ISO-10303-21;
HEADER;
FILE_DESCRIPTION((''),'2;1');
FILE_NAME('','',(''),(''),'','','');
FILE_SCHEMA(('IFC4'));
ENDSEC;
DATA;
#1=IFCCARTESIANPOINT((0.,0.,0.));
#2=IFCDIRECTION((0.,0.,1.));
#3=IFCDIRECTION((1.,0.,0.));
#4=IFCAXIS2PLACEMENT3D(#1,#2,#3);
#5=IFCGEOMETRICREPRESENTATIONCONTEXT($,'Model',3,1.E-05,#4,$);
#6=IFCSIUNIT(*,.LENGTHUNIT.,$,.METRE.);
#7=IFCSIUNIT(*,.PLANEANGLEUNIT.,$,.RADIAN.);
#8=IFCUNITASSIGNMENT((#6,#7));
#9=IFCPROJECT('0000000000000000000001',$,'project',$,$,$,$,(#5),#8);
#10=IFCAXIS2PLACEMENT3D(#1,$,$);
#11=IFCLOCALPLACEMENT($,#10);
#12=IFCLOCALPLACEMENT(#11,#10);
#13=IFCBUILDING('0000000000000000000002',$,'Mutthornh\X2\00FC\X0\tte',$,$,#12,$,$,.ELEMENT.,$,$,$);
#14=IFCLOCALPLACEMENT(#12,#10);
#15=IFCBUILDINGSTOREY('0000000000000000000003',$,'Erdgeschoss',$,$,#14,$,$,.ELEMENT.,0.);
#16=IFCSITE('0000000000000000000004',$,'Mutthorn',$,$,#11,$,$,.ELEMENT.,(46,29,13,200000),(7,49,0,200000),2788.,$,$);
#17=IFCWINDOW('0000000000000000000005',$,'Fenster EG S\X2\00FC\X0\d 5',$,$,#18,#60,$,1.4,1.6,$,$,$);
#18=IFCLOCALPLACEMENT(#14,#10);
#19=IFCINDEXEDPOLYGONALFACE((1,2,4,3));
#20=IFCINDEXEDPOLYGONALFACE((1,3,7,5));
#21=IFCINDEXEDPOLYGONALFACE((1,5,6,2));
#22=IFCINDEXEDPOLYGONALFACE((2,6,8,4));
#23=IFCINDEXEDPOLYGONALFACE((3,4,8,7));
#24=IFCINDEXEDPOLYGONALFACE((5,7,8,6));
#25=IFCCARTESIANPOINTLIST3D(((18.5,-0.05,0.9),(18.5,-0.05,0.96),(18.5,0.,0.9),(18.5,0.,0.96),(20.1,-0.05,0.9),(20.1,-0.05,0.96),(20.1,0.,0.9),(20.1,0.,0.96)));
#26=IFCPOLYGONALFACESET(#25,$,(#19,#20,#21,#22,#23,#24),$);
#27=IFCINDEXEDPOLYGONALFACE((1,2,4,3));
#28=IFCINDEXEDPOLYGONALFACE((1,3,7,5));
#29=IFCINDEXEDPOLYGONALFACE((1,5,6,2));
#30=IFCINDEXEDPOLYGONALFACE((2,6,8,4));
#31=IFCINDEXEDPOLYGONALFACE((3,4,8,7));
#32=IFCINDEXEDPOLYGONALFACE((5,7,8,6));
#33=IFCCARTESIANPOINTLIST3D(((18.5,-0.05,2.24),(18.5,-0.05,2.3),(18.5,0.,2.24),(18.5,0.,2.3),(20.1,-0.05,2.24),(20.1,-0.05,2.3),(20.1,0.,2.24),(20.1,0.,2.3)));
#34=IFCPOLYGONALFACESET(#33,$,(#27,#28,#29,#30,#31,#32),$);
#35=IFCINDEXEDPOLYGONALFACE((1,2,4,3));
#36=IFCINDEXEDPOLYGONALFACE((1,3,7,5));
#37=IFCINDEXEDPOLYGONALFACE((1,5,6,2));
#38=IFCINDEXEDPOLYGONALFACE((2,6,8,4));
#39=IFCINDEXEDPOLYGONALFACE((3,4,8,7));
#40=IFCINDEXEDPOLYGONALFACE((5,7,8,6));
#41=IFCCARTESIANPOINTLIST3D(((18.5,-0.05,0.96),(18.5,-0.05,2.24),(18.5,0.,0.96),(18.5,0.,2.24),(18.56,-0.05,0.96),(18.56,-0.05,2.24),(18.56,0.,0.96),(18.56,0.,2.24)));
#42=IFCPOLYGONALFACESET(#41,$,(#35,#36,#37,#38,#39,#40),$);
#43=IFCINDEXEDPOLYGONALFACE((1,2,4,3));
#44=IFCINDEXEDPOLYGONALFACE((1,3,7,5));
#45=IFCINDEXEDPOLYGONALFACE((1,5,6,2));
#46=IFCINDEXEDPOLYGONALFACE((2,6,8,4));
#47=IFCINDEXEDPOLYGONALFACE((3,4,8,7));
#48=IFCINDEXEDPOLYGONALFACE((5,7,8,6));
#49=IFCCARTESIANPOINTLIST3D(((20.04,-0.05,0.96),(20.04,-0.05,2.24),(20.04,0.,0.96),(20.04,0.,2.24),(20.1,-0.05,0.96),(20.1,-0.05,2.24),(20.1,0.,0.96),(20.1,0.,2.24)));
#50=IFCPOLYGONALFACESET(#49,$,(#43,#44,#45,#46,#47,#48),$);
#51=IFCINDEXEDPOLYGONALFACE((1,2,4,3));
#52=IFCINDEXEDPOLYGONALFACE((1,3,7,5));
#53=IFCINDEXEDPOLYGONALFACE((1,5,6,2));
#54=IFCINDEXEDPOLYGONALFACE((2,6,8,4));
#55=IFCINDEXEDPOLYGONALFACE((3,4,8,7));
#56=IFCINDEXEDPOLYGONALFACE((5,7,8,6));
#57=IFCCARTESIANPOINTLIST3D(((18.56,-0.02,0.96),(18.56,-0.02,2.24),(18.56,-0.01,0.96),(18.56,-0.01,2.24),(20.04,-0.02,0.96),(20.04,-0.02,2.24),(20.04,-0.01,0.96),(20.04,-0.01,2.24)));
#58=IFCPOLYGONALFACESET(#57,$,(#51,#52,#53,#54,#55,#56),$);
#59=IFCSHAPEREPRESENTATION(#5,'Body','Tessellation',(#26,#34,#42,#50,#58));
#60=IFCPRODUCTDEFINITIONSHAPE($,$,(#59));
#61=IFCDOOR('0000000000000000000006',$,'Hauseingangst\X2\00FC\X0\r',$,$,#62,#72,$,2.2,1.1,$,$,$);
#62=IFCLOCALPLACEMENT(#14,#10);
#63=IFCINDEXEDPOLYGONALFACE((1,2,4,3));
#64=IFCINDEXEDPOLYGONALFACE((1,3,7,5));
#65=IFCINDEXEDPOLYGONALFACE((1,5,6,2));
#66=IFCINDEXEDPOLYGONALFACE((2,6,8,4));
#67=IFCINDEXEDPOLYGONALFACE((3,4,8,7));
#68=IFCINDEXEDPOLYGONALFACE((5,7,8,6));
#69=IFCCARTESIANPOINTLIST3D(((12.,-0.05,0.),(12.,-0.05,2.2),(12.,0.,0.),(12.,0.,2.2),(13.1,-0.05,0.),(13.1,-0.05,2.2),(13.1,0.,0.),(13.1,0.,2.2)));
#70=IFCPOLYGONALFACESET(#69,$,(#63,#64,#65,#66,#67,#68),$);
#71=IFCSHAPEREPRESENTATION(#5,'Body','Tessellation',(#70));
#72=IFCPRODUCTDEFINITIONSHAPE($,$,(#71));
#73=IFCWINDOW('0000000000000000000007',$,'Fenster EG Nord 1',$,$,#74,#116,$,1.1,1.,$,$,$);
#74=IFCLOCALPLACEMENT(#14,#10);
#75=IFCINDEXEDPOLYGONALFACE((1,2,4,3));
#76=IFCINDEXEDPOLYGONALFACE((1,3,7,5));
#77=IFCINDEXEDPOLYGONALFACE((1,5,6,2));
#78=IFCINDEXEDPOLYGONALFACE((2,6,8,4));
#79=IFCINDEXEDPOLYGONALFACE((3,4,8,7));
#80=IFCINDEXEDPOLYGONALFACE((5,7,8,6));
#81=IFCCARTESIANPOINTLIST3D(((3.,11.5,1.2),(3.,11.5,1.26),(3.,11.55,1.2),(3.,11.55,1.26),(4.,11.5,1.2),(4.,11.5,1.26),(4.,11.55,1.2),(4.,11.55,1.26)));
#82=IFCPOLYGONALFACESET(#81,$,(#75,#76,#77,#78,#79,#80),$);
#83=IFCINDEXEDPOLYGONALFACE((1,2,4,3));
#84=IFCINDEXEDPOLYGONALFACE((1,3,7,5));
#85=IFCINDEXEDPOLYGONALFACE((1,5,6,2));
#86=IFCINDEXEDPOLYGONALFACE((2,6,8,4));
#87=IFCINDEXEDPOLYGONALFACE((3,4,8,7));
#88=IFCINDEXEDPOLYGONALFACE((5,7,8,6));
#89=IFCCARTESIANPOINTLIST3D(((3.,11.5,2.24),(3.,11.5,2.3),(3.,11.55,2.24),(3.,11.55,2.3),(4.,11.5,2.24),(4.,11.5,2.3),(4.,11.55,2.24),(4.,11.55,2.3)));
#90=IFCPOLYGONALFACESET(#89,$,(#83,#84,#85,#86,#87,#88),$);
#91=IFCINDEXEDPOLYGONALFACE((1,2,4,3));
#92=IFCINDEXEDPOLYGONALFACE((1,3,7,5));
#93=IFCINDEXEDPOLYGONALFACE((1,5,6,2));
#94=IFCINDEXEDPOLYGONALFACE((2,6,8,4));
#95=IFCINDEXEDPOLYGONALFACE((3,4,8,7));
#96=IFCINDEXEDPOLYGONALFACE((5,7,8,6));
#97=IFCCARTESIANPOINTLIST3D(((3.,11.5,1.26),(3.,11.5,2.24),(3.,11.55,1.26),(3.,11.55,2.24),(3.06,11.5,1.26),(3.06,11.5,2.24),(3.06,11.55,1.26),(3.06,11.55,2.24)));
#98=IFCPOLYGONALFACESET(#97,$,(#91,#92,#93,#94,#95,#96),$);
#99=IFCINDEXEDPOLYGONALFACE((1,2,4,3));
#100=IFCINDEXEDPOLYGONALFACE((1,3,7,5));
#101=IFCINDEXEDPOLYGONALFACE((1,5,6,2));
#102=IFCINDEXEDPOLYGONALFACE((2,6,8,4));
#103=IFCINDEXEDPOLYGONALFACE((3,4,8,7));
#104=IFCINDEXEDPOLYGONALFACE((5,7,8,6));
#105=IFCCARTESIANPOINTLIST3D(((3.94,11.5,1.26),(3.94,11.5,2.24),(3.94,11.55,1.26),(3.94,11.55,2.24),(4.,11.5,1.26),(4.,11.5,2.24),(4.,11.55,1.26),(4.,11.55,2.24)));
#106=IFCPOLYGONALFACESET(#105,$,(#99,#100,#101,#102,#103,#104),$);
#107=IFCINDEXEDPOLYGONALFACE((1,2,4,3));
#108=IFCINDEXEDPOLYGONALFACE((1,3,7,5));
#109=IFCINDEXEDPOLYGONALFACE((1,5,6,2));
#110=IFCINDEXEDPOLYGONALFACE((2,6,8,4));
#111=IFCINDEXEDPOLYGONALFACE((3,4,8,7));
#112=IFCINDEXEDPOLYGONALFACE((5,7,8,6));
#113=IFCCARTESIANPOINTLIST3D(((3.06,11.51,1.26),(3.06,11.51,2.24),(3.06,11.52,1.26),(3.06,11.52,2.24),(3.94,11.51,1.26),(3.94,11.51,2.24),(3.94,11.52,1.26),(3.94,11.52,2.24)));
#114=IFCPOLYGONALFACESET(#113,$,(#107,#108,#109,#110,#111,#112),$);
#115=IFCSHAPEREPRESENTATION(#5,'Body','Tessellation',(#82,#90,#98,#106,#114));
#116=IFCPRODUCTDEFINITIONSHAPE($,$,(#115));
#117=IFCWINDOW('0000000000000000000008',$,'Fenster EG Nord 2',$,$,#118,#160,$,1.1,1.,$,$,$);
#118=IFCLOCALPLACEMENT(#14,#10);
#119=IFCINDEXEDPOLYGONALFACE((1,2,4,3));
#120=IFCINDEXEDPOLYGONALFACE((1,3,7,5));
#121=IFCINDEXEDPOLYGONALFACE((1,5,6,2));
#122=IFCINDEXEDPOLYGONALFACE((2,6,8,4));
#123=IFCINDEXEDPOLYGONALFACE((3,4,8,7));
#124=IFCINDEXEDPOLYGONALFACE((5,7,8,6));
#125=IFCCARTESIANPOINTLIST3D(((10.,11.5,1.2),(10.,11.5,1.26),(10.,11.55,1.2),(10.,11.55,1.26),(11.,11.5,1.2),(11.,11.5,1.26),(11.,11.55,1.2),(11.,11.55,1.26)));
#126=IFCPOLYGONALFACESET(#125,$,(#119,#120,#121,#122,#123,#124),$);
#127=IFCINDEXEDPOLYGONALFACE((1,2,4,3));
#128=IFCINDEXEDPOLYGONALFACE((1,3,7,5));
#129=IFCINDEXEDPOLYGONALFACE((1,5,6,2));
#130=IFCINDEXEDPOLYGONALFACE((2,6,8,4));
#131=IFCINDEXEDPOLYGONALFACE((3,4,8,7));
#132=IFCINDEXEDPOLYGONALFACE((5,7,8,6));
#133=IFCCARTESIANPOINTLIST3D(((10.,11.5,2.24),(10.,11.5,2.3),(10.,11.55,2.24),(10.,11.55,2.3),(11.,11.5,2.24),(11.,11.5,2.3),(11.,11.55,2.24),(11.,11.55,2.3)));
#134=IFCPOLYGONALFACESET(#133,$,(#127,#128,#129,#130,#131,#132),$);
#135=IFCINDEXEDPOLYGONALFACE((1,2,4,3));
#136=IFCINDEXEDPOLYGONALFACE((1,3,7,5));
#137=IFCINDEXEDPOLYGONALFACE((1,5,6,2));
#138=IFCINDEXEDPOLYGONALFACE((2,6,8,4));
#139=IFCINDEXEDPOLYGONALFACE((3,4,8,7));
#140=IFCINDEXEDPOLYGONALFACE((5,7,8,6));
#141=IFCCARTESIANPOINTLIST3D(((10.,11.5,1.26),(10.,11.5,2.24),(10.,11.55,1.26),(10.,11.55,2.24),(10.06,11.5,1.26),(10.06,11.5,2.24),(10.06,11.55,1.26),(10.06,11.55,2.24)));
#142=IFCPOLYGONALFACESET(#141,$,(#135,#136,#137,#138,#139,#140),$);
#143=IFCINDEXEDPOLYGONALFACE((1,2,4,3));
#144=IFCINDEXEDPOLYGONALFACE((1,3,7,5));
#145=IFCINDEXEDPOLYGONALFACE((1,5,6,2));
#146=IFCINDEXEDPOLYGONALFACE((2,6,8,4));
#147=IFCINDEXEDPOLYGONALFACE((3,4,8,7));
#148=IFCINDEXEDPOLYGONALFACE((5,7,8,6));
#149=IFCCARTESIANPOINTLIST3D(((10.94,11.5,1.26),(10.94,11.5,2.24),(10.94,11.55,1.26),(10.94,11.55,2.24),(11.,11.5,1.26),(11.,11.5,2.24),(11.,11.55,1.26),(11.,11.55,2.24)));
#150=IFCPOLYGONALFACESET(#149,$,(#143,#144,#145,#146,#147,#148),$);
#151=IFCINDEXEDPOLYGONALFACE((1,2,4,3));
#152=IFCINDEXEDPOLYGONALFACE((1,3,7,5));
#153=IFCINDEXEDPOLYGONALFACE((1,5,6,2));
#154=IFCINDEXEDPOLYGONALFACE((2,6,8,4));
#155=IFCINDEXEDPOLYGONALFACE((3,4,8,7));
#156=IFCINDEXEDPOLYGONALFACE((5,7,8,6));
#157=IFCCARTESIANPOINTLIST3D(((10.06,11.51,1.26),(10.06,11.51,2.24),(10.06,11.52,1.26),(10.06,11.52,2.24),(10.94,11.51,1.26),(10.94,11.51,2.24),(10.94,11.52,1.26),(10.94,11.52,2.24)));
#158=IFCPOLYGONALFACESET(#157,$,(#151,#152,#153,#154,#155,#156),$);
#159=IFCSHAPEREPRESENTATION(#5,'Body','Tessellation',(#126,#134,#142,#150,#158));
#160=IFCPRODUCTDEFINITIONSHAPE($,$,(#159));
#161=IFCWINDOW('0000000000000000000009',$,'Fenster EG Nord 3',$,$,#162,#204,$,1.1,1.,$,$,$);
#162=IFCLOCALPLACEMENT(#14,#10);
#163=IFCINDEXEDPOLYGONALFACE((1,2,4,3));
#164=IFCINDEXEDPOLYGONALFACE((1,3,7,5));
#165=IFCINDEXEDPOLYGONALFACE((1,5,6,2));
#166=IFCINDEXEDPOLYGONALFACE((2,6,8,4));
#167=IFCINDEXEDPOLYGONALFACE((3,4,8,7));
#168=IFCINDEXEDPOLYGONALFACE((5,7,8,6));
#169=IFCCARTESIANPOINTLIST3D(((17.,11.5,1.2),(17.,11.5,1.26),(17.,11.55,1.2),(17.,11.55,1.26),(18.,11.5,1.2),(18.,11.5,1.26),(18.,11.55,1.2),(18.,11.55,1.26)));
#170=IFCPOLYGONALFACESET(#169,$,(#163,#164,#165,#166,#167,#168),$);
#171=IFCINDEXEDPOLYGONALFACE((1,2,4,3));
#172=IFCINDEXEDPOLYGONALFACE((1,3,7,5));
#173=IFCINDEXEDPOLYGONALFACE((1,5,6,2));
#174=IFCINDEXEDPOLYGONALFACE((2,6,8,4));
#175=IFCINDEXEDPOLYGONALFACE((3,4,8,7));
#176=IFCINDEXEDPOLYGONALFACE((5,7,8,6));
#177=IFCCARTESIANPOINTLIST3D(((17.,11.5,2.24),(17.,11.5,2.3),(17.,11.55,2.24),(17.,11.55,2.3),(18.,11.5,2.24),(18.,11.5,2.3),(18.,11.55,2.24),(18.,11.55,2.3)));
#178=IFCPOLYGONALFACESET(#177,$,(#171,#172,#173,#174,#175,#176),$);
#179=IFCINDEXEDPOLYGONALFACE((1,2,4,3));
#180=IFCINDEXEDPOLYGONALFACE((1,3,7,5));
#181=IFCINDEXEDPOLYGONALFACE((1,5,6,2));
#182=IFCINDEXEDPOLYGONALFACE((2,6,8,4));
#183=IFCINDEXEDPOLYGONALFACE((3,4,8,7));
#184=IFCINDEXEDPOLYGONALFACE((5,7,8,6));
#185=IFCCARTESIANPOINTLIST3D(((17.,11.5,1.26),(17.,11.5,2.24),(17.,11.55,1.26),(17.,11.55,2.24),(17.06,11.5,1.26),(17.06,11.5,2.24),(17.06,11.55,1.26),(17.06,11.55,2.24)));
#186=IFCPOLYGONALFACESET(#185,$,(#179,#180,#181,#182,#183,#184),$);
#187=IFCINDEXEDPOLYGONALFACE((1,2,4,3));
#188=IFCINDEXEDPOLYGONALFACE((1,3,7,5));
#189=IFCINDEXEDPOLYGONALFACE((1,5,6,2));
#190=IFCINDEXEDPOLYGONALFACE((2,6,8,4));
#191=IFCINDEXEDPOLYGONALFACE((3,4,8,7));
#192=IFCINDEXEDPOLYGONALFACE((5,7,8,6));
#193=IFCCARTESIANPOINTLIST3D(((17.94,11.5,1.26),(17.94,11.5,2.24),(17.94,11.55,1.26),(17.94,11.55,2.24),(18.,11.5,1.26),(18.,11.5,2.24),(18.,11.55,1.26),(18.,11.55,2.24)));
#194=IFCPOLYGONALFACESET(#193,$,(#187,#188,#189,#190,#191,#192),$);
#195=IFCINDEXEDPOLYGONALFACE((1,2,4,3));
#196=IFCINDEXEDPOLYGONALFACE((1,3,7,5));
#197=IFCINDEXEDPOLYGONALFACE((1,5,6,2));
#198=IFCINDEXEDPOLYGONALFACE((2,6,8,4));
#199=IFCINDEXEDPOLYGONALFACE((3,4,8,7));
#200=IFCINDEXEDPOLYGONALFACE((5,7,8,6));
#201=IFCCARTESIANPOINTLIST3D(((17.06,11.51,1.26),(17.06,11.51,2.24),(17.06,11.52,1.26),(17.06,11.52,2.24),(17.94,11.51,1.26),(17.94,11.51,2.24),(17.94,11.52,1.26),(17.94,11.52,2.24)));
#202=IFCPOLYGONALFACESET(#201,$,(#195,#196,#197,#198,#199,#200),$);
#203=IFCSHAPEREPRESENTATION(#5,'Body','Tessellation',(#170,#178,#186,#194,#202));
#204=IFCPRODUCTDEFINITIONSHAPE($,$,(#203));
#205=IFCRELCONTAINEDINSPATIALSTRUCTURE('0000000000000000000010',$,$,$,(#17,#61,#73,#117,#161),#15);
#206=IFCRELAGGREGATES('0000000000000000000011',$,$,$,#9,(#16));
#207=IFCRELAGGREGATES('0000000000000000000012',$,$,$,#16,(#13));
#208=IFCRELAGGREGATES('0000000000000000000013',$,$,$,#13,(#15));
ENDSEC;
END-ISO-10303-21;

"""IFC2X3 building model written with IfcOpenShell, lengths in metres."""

from ifc_helpers import new_model, si_unit, frame, frame_2d, origin, origin_with_axes, place, context, project, spatial, rectangle, extrude, element, save


model = new_model("IFC2X3")

# Units and contexts
model_context = context("Model", 3, precision=1e-05, world=origin_with_axes())
ifc_project = project(units=[si_unit("LENGTHUNIT", "METRE"), si_unit("PLANEANGLEUNIT", "RADIAN")], contexts=[model_context])

# Site, building, storey
site_placement = place(None, origin())
site = spatial("IfcSite", under=ifc_project, at=site_placement, Name="Mutthorn", CompositionType="ELEMENT", RefLatitude=(46, 29, 13, 200000), RefLongitude=(7, 49, 0, 200000), RefElevation=2788.0)
building_placement = place(site_placement, origin())
building = spatial("IfcBuilding", under=site, at=building_placement, Name="Mutthornhütte", CompositionType="ELEMENT")
storey_placement = place(building_placement, origin())
storey = spatial("IfcBuildingStorey", under=building, at=storey_placement, Name="Erdgeschoss", CompositionType="ELEMENT", Elevation=0.0)

# Window
window_1_placement = place(storey_placement, origin())
element("IfcWindow", 1, at=window_1_placement, inside=storey, Name="Fenster EG Süd 5", OverallHeight=1.4, OverallWidth=1.6, context=model_context, shape_type="SweptSolid", body=[
    extrude(rectangle(XDim=1.6, YDim=0.05, at=frame_2d((0.8, 0.025))), frame((18.5, -0.05, 0.9)), (0.0, 0.0, 1.0), 0.06),
    extrude(rectangle(XDim=1.6, YDim=0.05, at=frame_2d((0.8, 0.025))), frame((18.5, -0.05, 2.24)), (0.0, 0.0, 1.0), 0.06),
    extrude(rectangle(XDim=0.06, YDim=0.05, at=frame_2d((0.03, 0.025))), frame((18.5, -0.05, 0.96)), (0.0, 0.0, 1.0), 1.28),
    extrude(rectangle(XDim=0.06, YDim=0.05, at=frame_2d((0.03, 0.025))), frame((20.04, -0.05, 0.96)), (0.0, 0.0, 1.0), 1.28),
    extrude(rectangle(XDim=1.48, YDim=0.01, at=frame_2d((0.74, 0.005))), frame((18.56, -0.02, 0.96)), (0.0, 0.0, 1.0), 1.28),
])

# Door
door_placement = place(storey_placement, origin())
element("IfcDoor", 2, at=door_placement, inside=storey, Name="Hauseingangstür", OverallHeight=2.2, OverallWidth=1.1, context=model_context, shape_type="SweptSolid", body=[
    extrude(rectangle(XDim=1.1, YDim=0.05, at=frame_2d((0.55, 0.025))), frame((12.0, -0.05, 0.0)), (0.0, 0.0, 1.0), 2.2),
])

# Windows
window_2_placement = place(storey_placement, origin())
element("IfcWindow", 3, at=window_2_placement, inside=storey, Name="Fenster EG Nord 1", OverallHeight=1.1, OverallWidth=1.0, context=model_context, shape_type="SweptSolid", body=[
    extrude(rectangle(XDim=1.0, YDim=0.05, at=frame_2d((0.5, 0.025))), frame((3.0, 11.5, 1.2)), (0.0, 0.0, 1.0), 0.06),
    extrude(rectangle(XDim=1.0, YDim=0.05, at=frame_2d((0.5, 0.025))), frame((3.0, 11.5, 2.24)), (0.0, 0.0, 1.0), 0.06),
    extrude(rectangle(XDim=0.06, YDim=0.05, at=frame_2d((0.03, 0.025))), frame((3.0, 11.5, 1.26)), (0.0, 0.0, 1.0), 0.98),
    extrude(rectangle(XDim=0.06, YDim=0.05, at=frame_2d((0.03, 0.025))), frame((3.94, 11.5, 1.26)), (0.0, 0.0, 1.0), 0.98),
    extrude(rectangle(XDim=0.88, YDim=0.01, at=frame_2d((0.44, 0.005))), frame((3.06, 11.51, 1.26)), (0.0, 0.0, 1.0), 0.98),
])
window_3_placement = place(storey_placement, origin())
element("IfcWindow", 4, at=window_3_placement, inside=storey, Name="Fenster EG Nord 2", OverallHeight=1.1, OverallWidth=1.0, context=model_context, shape_type="SweptSolid", body=[
    extrude(rectangle(XDim=1.0, YDim=0.05, at=frame_2d((0.5, 0.025))), frame((10.0, 11.5, 1.2)), (0.0, 0.0, 1.0), 0.06),
    extrude(rectangle(XDim=1.0, YDim=0.05, at=frame_2d((0.5, 0.025))), frame((10.0, 11.5, 2.24)), (0.0, 0.0, 1.0), 0.06),
    extrude(rectangle(XDim=0.06, YDim=0.05, at=frame_2d((0.03, 0.025))), frame((10.0, 11.5, 1.26)), (0.0, 0.0, 1.0), 0.98),
    extrude(rectangle(XDim=0.06, YDim=0.05, at=frame_2d((0.03, 0.025))), frame((10.94, 11.5, 1.26)), (0.0, 0.0, 1.0), 0.98),
    extrude(rectangle(XDim=0.88, YDim=0.01, at=frame_2d((0.44, 0.005))), frame((10.06, 11.51, 1.26)), (0.0, 0.0, 1.0), 0.98),
])
window_4_placement = place(storey_placement, origin())
element("IfcWindow", 5, at=window_4_placement, inside=storey, Name="Fenster EG Nord 3", OverallHeight=1.1, OverallWidth=1.0, context=model_context, shape_type="SweptSolid", body=[
    extrude(rectangle(XDim=1.0, YDim=0.05, at=frame_2d((0.5, 0.025))), frame((17.0, 11.5, 1.2)), (0.0, 0.0, 1.0), 0.06),
    extrude(rectangle(XDim=1.0, YDim=0.05, at=frame_2d((0.5, 0.025))), frame((17.0, 11.5, 2.24)), (0.0, 0.0, 1.0), 0.06),
    extrude(rectangle(XDim=0.06, YDim=0.05, at=frame_2d((0.03, 0.025))), frame((17.0, 11.5, 1.26)), (0.0, 0.0, 1.0), 0.98),
    extrude(rectangle(XDim=0.06, YDim=0.05, at=frame_2d((0.03, 0.025))), frame((17.94, 11.5, 1.26)), (0.0, 0.0, 1.0), 0.98),
    extrude(rectangle(XDim=0.88, YDim=0.01, at=frame_2d((0.44, 0.005))), frame((17.06, 11.51, 1.26)), (0.0, 0.0, 1.0), 0.98),
])

save(model, "model.ifc")
